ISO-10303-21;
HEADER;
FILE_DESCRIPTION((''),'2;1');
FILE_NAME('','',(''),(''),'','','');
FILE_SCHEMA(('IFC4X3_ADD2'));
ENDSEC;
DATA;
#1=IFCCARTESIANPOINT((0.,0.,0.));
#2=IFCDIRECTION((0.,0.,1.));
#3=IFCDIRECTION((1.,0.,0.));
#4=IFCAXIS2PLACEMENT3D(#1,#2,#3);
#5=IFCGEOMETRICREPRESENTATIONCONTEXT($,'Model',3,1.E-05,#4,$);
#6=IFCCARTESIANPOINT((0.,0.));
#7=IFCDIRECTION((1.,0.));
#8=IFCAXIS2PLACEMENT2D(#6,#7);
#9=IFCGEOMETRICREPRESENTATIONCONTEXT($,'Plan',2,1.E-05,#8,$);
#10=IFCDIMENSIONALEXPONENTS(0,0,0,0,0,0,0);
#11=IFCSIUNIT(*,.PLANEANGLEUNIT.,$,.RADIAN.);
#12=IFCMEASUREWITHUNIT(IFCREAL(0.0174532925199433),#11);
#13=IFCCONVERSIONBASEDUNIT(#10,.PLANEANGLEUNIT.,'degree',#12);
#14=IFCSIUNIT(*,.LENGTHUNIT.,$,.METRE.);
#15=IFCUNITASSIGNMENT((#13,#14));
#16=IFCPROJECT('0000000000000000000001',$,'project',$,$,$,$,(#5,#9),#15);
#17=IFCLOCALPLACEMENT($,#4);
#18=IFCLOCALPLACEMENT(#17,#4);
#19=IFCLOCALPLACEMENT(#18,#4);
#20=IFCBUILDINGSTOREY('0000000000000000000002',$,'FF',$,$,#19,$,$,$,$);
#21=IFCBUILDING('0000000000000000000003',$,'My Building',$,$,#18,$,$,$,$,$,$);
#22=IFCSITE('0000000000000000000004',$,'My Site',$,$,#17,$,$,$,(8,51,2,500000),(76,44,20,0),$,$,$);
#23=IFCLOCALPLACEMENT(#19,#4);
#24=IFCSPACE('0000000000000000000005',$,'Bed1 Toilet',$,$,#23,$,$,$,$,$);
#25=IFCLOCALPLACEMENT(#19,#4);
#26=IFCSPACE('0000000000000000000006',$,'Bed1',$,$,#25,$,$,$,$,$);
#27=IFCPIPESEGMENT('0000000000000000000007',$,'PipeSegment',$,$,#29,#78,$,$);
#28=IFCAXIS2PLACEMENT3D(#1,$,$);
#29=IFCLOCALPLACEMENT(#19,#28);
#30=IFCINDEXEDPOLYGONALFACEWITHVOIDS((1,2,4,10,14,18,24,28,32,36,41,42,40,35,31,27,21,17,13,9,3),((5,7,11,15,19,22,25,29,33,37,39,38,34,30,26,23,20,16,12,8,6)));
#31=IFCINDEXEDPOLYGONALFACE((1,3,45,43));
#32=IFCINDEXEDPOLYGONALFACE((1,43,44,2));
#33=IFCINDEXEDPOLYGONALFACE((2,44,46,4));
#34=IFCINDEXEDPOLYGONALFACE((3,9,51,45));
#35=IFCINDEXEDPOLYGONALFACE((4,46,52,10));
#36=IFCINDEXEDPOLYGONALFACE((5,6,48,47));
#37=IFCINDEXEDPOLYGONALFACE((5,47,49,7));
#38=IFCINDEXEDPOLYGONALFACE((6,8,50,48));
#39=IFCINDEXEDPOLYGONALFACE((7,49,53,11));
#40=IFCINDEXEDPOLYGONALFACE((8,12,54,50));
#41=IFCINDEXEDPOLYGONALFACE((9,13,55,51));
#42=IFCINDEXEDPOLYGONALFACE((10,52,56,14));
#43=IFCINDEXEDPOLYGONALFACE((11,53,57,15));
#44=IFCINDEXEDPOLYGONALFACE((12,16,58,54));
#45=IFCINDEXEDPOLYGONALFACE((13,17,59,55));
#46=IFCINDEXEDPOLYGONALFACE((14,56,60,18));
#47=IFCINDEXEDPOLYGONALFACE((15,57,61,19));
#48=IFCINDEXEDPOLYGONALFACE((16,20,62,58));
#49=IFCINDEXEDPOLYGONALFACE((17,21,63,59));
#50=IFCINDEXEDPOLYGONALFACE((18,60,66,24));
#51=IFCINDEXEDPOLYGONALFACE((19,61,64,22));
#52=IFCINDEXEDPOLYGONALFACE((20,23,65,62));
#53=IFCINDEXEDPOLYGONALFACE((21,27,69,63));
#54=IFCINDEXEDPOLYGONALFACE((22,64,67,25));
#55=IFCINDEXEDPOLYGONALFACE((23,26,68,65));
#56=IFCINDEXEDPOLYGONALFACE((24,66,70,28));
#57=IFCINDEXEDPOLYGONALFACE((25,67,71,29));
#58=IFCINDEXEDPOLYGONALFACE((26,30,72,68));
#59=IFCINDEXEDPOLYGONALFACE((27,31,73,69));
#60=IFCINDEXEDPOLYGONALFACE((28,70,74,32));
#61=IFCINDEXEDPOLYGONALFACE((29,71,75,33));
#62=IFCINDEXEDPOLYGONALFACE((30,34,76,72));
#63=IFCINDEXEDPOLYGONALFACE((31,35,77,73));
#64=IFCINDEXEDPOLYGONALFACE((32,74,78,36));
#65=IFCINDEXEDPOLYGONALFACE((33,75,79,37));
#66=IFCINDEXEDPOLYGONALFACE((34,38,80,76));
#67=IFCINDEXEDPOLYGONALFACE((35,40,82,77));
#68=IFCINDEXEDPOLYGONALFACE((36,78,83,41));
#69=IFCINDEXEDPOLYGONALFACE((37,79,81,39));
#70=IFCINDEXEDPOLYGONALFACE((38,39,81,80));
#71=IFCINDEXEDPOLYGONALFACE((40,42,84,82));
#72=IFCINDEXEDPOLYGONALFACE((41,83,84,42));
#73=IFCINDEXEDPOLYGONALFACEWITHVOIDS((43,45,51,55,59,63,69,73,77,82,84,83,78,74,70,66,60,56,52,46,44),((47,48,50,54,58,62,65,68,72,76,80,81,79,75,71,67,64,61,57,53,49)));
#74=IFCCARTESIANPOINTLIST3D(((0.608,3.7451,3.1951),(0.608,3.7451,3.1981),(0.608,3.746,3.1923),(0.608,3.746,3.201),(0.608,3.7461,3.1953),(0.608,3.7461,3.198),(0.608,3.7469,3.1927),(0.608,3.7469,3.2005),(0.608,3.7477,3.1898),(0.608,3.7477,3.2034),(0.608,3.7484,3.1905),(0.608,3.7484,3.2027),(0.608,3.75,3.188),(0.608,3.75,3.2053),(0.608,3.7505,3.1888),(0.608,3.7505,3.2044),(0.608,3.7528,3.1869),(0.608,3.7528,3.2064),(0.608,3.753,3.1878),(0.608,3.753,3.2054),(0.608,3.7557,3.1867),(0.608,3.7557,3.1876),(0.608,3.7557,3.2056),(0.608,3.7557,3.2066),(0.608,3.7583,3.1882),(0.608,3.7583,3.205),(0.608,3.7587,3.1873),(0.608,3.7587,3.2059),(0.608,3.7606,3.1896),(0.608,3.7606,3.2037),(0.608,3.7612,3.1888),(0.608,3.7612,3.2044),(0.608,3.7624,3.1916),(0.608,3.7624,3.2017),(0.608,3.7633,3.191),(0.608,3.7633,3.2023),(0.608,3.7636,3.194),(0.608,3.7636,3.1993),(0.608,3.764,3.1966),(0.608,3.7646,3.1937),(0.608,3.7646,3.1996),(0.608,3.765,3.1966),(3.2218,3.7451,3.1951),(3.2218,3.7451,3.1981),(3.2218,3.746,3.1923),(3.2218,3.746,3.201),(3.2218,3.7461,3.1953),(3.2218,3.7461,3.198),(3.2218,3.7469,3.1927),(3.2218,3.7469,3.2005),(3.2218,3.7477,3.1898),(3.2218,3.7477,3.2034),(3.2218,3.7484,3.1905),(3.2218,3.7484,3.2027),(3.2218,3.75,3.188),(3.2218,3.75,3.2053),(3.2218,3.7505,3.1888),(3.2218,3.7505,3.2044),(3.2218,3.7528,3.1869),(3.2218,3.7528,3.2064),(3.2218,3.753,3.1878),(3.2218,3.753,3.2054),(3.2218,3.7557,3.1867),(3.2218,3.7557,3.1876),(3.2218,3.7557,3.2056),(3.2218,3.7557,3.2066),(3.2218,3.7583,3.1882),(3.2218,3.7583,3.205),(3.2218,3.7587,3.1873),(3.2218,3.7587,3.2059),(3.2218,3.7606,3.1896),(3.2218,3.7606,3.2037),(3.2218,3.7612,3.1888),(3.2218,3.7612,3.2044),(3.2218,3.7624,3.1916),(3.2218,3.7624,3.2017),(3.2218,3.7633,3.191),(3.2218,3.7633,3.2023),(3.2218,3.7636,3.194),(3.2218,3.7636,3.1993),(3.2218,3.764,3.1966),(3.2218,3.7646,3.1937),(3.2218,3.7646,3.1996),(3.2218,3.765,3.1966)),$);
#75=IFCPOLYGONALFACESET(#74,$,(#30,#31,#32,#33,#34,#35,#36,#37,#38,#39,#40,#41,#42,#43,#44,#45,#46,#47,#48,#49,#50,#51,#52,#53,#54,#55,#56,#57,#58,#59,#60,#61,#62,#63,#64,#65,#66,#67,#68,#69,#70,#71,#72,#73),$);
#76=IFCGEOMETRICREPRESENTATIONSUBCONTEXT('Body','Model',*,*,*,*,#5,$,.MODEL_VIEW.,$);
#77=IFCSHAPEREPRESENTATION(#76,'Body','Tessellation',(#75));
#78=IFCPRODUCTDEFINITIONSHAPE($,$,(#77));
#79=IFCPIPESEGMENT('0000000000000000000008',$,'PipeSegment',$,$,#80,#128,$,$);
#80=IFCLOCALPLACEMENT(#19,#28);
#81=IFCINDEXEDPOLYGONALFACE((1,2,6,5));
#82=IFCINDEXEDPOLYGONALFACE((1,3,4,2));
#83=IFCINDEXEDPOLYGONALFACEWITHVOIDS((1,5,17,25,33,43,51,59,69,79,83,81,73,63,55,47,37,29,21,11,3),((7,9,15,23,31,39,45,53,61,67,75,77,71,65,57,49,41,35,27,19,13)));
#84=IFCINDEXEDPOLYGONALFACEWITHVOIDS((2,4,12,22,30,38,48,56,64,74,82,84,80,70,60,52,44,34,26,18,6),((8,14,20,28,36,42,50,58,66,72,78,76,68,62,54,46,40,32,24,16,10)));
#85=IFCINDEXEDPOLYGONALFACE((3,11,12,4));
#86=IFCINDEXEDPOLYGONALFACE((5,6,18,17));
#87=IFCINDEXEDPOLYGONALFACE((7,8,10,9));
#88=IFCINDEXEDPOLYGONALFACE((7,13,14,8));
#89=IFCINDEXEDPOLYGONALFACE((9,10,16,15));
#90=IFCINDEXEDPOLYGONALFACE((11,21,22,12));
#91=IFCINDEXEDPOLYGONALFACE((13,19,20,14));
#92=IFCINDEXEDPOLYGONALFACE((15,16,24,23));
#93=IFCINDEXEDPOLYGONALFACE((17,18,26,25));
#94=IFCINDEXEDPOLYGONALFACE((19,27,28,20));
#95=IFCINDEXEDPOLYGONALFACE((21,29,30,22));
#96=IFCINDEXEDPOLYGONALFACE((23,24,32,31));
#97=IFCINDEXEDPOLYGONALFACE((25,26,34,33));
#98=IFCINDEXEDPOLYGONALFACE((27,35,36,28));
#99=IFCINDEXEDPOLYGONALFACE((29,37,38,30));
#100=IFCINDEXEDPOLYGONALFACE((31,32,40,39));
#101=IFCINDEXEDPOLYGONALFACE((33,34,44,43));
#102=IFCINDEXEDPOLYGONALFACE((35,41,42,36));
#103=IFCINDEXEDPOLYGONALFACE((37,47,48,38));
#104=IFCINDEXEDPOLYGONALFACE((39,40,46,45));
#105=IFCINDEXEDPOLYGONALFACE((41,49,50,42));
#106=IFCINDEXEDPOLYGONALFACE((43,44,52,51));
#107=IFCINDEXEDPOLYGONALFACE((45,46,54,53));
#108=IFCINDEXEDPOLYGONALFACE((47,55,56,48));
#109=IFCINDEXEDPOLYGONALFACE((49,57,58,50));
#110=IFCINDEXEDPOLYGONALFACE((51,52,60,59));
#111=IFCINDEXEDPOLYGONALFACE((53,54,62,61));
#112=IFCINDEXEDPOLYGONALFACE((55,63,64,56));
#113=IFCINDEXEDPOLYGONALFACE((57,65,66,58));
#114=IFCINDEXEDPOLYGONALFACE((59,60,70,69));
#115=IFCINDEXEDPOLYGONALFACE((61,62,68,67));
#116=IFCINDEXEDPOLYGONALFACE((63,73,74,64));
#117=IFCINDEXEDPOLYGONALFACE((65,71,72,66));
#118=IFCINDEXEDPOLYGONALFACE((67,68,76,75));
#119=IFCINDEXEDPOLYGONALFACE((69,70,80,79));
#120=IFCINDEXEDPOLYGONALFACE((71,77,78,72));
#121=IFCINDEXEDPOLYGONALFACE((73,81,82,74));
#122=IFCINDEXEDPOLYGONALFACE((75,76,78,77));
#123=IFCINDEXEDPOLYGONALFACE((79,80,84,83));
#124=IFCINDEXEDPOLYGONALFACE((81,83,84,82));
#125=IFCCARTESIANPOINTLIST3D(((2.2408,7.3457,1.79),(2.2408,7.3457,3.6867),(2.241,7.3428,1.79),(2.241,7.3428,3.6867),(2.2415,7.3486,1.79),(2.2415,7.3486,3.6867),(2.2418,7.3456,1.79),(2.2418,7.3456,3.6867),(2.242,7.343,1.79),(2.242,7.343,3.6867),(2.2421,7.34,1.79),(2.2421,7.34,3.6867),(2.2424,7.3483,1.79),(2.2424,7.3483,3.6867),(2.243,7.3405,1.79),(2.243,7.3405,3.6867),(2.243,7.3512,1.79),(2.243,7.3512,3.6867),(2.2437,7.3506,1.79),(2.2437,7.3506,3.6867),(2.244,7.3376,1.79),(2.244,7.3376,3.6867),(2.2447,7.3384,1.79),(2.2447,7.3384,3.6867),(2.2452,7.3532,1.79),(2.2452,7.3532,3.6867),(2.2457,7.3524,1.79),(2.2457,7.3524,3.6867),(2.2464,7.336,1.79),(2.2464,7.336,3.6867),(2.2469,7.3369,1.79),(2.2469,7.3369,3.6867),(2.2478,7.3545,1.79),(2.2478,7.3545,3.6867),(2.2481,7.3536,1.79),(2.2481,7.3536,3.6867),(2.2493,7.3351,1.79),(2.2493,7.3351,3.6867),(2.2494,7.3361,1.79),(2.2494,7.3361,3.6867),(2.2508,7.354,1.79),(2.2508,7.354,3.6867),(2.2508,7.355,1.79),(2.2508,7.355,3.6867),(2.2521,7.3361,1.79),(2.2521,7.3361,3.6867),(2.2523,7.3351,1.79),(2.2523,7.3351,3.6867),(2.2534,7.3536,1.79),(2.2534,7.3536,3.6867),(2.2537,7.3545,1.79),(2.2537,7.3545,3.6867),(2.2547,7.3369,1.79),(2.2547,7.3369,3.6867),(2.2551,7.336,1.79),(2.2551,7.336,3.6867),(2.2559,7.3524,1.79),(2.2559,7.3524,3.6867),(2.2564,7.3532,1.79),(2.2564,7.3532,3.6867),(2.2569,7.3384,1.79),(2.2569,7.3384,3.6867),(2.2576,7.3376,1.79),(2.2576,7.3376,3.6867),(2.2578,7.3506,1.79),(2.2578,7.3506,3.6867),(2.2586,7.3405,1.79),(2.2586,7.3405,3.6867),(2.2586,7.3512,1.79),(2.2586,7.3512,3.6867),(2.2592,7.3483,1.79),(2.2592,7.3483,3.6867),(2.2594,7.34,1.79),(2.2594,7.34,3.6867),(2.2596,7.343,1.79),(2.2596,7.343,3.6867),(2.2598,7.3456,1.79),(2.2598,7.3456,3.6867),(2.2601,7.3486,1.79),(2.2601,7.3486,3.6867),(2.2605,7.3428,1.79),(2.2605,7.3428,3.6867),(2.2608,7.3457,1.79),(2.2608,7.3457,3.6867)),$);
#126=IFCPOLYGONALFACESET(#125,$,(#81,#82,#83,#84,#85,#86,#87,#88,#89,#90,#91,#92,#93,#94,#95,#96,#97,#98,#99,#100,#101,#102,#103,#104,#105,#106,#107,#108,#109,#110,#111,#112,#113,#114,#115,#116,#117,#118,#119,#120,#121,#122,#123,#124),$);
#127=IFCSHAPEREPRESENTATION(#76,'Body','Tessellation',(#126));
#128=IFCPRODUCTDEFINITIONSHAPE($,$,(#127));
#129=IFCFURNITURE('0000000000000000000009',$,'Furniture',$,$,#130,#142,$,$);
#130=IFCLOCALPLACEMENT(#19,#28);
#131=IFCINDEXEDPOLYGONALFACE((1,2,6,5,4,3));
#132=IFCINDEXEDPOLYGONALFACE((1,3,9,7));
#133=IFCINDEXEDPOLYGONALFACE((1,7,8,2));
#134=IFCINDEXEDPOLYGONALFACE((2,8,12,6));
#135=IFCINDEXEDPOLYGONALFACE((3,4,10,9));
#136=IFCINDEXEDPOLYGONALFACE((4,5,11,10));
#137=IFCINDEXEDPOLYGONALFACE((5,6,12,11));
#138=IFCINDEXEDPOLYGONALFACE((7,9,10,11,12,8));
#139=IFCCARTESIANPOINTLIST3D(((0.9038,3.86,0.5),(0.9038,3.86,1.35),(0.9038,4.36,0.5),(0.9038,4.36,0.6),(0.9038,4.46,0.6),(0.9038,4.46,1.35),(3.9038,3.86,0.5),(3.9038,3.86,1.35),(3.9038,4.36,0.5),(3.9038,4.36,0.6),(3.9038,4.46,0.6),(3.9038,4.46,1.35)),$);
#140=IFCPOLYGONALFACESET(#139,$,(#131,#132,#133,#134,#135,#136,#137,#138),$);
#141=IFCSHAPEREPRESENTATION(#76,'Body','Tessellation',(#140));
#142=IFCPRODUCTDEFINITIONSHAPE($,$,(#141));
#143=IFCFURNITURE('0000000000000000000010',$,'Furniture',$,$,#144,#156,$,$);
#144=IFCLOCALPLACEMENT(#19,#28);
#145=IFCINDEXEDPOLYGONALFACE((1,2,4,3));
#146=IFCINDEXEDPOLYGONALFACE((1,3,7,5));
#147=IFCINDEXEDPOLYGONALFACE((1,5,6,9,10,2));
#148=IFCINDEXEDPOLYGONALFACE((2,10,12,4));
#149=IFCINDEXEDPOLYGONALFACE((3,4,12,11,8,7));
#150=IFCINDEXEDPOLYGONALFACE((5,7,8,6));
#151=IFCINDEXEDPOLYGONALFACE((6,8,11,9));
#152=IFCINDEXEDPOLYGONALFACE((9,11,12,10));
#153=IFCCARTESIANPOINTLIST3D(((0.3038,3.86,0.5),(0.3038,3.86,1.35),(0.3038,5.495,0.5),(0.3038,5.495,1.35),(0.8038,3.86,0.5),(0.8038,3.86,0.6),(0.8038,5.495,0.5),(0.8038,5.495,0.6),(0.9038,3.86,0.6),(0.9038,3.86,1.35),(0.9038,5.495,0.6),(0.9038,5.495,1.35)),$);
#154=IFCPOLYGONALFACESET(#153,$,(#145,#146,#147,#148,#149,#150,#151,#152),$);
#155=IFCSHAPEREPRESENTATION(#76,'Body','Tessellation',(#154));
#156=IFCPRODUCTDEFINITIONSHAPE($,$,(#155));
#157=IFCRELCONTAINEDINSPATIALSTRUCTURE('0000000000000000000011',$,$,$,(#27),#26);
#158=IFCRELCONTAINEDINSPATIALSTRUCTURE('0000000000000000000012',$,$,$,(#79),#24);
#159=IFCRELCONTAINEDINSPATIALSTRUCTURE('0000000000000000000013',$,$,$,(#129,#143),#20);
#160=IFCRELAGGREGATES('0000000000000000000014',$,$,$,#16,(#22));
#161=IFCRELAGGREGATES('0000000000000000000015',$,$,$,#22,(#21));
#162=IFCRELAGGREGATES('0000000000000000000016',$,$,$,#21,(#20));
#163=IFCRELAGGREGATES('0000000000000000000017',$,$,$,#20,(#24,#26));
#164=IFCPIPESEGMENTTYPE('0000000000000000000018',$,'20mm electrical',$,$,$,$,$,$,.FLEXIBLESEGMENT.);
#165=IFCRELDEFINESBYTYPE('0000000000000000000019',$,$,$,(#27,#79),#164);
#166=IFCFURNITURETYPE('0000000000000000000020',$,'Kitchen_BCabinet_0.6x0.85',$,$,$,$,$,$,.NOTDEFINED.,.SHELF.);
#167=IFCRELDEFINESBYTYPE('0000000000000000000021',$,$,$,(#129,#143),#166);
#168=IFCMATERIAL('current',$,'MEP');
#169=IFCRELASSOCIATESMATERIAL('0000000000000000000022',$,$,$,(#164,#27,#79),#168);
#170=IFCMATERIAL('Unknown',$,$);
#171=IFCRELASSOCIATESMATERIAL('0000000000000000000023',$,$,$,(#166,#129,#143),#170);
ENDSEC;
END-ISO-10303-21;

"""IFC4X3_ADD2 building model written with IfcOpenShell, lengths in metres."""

from ifc_helpers import new_model, entity, si_unit, converted_unit, frame, origin_with_axes, origin_2d_with_axis, place, context, subcontext, project, spatial, indexed_curve, hollow_circle, outline, extrude, material, material_profile, profile_set, profile_usage, type_object, element, save


model = new_model("IFC4X3_ADD2")

# Units and contexts
model_context = context("Model", 3, precision=1e-05, world=origin_with_axes())
plan_context = context("Plan", 2, precision=1e-05, world=origin_2d_with_axis())
body_context_1 = subcontext(model_context, "Body", "Model", "MODEL_VIEW")
ifc_project = project(units=[converted_unit("PLANEANGLEUNIT", "degree", entity("IfcReal", 0.0174532925199433), si_unit("PLANEANGLEUNIT", "RADIAN"), dimensions=[0, 0, 0, 0, 0, 0, 0]), si_unit("LENGTHUNIT", "METRE")], contexts=[model_context, plan_context])

# Site, building, storey
site_placement = place(None, origin_with_axes())
site = spatial("IfcSite", under=ifc_project, at=site_placement, Name="My Site", RefLatitude=(8, 51, 2, 500000), RefLongitude=(76, 44, 20, 0))
building_placement = place(site_placement, origin_with_axes())
building = spatial("IfcBuilding", under=site, at=building_placement, Name="My Building")
storey_placement = place(building_placement, origin_with_axes())
storey = spatial("IfcBuildingStorey", under=building, at=storey_placement, Name="FF")

# Shared definitions
space_1_placement = place(storey_placement, origin_with_axes())
space_1 = spatial("IfcSpace", under=storey, at=space_1_placement, Name="Bed1 Toilet")

# Shared definitions
space_2_placement = place(storey_placement, origin_with_axes())
space_2 = spatial("IfcSpace", under=storey, at=space_2_placement, Name="Bed1")

# Pipe segments
ifc_material_1 = material(Name="current", Category="MEP")
ifc_material_profile_1 = material_profile(ifc_material_1, hollow_circle(Radius=0.01, WallThickness=0.001))
ifc_profile_set_1 = profile_set([ifc_material_profile_1], Name="current")
pipe_segment_type = type_object("IfcPipeSegmentType", Name="20mm electrical", PredefinedType="FLEXIBLESEGMENT", material=ifc_profile_set_1)
ifc_profile_usage_1 = profile_usage(ifc_profile_set_1, cardinal=5)
pipe_segment_1_placement = place(space_2_placement, frame((0.608, 3.755, 3.1966), z_axis=(1.0, 0.0, 0.0), x_axis=(0.0, 1.0, 0.0)))
element("IfcPipeSegment", 1, at=pipe_segment_1_placement, inside=space_2, type_object=pipe_segment_type, material=ifc_profile_usage_1, Name="PipeSegment", context=body_context_1, shape_type="SweptSolid", body=[
    extrude(hollow_circle(Radius=0.01, WallThickness=0.001), origin_with_axes(), (0.0, 0.0, 1.0), 2.6139),
])
ifc_profile_usage_2 = profile_usage(ifc_profile_set_1, cardinal=5)
pipe_segment_2_placement = place(space_1_placement, frame((2.2508, 7.345, 1.79), z_axis=(0.0, 0.0, 1.0), x_axis=(0.0, 1.0, 0.0)))
element("IfcPipeSegment", 2, at=pipe_segment_2_placement, inside=space_1, type_object=pipe_segment_type, material=ifc_profile_usage_2, Name="PipeSegment", context=body_context_1, shape_type="SweptSolid", body=[
    extrude(hollow_circle(Radius=0.01, WallThickness=0.001), origin_with_axes(), (0.0, 0.0, 1.0), 1.8967),
])

# Furniture
ifc_material_2 = material(Name="Unknown")
ifc_material_profile_2 = material_profile(ifc_material_2, outline(indexed_curve([(0.5, 0.0), (0.0, 0.0), (0.0, 0.85), (0.6, 0.85), (0.6, 0.1), (0.5, 0.1), (0.5, 0.0)])))
ifc_profile_set_2 = profile_set([ifc_material_profile_2], Name="blank")
ifc_profile_usage_3 = profile_usage(ifc_profile_set_2, cardinal=5)
furniture_type = type_object("IfcFurnitureType", Name="Kitchen_BCabinet_0.6x0.85", AssemblyPlace="NOTDEFINED", PredefinedType="SHELF", material=ifc_profile_set_2)
furniture_1_placement = place(storey_placement, frame((0.9038, 3.86, 0.5), z_axis=(1.0, 0.0, 0.0), x_axis=(0.0, 1.0, 0.0)))
element("IfcFurniture", 3, at=furniture_1_placement, inside=storey, type_object=furniture_type, material=ifc_profile_usage_3, Name="Furniture", context=body_context_1, shape_type="SweptSolid", body=[
    extrude(outline(indexed_curve([(0.5, 0.0), (0.0, 0.0), (0.0, 0.85), (0.6, 0.85), (0.6, 0.1), (0.5, 0.1), (0.5, 0.0)])), origin_with_axes(), (0.0, 0.0, 1.0), 3.0),
])
ifc_profile_usage_4 = profile_usage(ifc_profile_set_2, cardinal=5)
furniture_2_placement = place(storey_placement, frame((0.3038, 5.495, 0.5), z_axis=(0.0, -1.0, 0.0), x_axis=(1.0, 0.0, 0.0)))
element("IfcFurniture", 4, at=furniture_2_placement, inside=storey, type_object=furniture_type, material=ifc_profile_usage_4, Name="Furniture", context=body_context_1, shape_type="SweptSolid", body=[
    extrude(outline(indexed_curve([(0.5, 0.0), (0.0, 0.0), (0.0, 0.85), (0.6, 0.85), (0.6, 0.1), (0.5, 0.1), (0.5, 0.0)])), origin_with_axes(), (0.0, 0.0, 1.0), 1.635),
])

save(model, "model.ifc")
